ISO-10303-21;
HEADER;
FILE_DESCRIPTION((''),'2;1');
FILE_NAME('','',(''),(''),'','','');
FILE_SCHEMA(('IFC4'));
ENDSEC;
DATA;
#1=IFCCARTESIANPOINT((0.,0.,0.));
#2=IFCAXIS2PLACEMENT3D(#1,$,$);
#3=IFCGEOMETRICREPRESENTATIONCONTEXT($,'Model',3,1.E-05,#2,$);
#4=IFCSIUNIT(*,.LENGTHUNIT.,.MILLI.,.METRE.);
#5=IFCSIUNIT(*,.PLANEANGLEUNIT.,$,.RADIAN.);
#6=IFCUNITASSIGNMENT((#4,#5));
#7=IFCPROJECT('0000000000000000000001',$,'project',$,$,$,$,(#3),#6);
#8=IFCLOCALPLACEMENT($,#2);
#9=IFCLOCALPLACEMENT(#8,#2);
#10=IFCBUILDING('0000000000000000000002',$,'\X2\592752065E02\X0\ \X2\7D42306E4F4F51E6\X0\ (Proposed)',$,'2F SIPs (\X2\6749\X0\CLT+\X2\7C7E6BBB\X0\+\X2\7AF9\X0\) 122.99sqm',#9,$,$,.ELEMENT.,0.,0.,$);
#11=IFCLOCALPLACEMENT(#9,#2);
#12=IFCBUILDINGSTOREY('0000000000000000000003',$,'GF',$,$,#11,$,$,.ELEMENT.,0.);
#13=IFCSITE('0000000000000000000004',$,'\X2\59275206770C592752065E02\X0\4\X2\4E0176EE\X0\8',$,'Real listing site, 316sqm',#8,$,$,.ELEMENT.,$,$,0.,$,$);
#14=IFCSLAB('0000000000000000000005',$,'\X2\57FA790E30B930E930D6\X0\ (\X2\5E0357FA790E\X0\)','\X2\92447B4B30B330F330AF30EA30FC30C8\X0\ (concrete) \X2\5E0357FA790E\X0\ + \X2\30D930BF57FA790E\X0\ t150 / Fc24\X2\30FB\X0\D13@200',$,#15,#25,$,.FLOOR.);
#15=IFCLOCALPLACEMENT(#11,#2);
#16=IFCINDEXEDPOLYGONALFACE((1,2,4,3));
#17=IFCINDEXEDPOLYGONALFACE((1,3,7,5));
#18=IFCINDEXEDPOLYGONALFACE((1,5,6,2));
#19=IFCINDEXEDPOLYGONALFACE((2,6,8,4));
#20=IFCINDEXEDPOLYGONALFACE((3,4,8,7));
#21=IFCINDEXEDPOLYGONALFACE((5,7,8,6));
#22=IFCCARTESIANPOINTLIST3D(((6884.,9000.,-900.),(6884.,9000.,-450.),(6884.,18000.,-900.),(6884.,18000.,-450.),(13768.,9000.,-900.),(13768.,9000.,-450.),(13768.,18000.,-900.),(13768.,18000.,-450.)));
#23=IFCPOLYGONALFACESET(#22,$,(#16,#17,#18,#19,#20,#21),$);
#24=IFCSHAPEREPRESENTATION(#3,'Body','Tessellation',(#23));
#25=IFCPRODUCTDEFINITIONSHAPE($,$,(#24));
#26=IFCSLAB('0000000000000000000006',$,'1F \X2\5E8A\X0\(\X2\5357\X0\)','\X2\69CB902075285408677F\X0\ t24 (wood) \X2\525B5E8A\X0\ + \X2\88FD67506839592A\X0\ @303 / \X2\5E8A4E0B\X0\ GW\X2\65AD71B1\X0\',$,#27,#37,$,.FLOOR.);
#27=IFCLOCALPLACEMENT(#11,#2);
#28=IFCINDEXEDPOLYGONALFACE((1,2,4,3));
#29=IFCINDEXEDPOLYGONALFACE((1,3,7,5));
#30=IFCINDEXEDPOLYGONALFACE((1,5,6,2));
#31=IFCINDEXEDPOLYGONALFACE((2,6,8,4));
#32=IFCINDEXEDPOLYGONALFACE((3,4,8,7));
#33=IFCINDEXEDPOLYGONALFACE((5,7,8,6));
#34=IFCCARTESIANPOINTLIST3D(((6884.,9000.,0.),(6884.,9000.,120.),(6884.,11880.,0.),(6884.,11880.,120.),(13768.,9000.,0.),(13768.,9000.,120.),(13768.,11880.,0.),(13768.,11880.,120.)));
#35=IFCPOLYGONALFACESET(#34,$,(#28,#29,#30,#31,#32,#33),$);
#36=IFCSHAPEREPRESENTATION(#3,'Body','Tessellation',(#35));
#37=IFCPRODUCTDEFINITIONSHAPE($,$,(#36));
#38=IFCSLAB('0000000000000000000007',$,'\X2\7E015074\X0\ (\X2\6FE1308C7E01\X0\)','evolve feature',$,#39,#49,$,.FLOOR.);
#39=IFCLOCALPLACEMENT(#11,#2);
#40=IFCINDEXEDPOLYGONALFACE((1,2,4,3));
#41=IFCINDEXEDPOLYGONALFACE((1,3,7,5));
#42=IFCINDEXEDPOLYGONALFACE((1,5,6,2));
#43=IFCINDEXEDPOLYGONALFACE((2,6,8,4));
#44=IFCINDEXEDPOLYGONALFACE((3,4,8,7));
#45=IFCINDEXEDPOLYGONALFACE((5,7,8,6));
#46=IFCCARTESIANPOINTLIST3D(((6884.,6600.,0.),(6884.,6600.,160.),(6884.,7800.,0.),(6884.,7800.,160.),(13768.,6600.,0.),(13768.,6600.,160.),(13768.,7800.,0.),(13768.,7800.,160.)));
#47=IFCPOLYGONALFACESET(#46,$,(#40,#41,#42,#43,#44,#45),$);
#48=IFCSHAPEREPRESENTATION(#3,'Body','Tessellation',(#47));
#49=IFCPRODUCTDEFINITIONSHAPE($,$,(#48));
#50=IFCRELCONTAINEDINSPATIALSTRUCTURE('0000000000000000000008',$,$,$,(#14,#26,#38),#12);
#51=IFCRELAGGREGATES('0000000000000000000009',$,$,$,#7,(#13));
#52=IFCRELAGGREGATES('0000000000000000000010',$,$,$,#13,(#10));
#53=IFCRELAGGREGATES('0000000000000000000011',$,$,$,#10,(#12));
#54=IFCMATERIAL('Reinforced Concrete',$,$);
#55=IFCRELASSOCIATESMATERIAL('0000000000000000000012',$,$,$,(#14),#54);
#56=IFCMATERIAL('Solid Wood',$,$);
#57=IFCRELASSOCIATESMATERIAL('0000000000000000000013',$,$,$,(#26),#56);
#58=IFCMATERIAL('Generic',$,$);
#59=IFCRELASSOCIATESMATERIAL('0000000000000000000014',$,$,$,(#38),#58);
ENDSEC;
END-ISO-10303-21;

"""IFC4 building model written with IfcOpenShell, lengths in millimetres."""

from ifc_helpers import new_model, si_unit, frame, frame_2d, origin, place, context, project, spatial, rectangle, extrude, material, element, save


model = new_model("IFC4")

# Units and contexts
model_context = context("Model", 3, precision=1e-05, world=origin())
ifc_project = project(units=[si_unit("LENGTHUNIT", "METRE", prefix="MILLI"), si_unit("PLANEANGLEUNIT", "RADIAN")], contexts=[model_context])

# Site, building, storey
site_placement = place(None, origin())
site = spatial("IfcSite", under=ifc_project, at=site_placement, Name="大分県大分市4丁目8", ObjectType="Real listing site, 316sqm", CompositionType="ELEMENT", RefElevation=0.0)
building_placement = place(site_placement, origin())
building = spatial("IfcBuilding", under=site, at=building_placement, Name="大分市 終の住処 (Proposed)", ObjectType="2F SIPs (杉CLT+籾殻+竹) 122.99sqm", CompositionType="ELEMENT", ElevationOfRefHeight=0.0, ElevationOfTerrain=0.0)
storey_placement = place(building_placement, origin())
storey = spatial("IfcBuildingStorey", under=building, at=storey_placement, Name="GF", CompositionType="ELEMENT", Elevation=0.0)

# Slabs
ifc_material_1 = material(Name="Reinforced Concrete")
slab_1_placement = place(storey_placement, frame((3442.0, 4500.0, -450.0)))
element("IfcSlab", 1, at=slab_1_placement, inside=storey, material=ifc_material_1, Name="基礎スラブ (布基礎)", Description="鉄筋コンクリート (concrete) 布基礎 + ベタ基礎 t150 / Fc24・D13@200", PredefinedType="FLOOR", context=model_context, shape_type="SweptSolid", body=[
    extrude(rectangle(XDim=6884.0, YDim=9000.0, at=frame_2d((3442.0, 4500.0))), frame((3442.0, 4500.0, -450.0)), (0.0, 0.0, 1.0), 450.0),
])
ifc_material_2 = material(Name="Solid Wood")
slab_2_placement = place(storey_placement, frame((3442.0, 4500.0, 0.0)))
element("IfcSlab", 2, at=slab_2_placement, inside=storey, material=ifc_material_2, Name="1F 床(南)", Description="構造用合板 t24 (wood) 剛床 + 製材根太 @303 / 床下 GW断熱", PredefinedType="FLOOR", context=model_context, shape_type="SweptSolid", body=[
    extrude(rectangle(XDim=6884.0, YDim=2880.0, at=frame_2d((3442.0, 1440.0))), frame((3442.0, 4500.0, 0.0)), (0.0, 0.0, 1.0), 120.0),
])
ifc_material_3 = material(Name="Generic")
slab_3_placement = place(storey_placement, frame((3442.0, 3300.0, 0.0)))
element("IfcSlab", 3, at=slab_3_placement, inside=storey, material=ifc_material_3, Name="縁側 (濡れ縁)", Description="evolve feature", PredefinedType="FLOOR", context=model_context, shape_type="SweptSolid", body=[
    extrude(rectangle(XDim=6884.0, YDim=1200.0, at=frame_2d((3442.0, 600.0))), frame((3442.0, 3300.0, 0.0)), (0.0, 0.0, 1.0), 160.0),
])

save(model, "model.ifc")
